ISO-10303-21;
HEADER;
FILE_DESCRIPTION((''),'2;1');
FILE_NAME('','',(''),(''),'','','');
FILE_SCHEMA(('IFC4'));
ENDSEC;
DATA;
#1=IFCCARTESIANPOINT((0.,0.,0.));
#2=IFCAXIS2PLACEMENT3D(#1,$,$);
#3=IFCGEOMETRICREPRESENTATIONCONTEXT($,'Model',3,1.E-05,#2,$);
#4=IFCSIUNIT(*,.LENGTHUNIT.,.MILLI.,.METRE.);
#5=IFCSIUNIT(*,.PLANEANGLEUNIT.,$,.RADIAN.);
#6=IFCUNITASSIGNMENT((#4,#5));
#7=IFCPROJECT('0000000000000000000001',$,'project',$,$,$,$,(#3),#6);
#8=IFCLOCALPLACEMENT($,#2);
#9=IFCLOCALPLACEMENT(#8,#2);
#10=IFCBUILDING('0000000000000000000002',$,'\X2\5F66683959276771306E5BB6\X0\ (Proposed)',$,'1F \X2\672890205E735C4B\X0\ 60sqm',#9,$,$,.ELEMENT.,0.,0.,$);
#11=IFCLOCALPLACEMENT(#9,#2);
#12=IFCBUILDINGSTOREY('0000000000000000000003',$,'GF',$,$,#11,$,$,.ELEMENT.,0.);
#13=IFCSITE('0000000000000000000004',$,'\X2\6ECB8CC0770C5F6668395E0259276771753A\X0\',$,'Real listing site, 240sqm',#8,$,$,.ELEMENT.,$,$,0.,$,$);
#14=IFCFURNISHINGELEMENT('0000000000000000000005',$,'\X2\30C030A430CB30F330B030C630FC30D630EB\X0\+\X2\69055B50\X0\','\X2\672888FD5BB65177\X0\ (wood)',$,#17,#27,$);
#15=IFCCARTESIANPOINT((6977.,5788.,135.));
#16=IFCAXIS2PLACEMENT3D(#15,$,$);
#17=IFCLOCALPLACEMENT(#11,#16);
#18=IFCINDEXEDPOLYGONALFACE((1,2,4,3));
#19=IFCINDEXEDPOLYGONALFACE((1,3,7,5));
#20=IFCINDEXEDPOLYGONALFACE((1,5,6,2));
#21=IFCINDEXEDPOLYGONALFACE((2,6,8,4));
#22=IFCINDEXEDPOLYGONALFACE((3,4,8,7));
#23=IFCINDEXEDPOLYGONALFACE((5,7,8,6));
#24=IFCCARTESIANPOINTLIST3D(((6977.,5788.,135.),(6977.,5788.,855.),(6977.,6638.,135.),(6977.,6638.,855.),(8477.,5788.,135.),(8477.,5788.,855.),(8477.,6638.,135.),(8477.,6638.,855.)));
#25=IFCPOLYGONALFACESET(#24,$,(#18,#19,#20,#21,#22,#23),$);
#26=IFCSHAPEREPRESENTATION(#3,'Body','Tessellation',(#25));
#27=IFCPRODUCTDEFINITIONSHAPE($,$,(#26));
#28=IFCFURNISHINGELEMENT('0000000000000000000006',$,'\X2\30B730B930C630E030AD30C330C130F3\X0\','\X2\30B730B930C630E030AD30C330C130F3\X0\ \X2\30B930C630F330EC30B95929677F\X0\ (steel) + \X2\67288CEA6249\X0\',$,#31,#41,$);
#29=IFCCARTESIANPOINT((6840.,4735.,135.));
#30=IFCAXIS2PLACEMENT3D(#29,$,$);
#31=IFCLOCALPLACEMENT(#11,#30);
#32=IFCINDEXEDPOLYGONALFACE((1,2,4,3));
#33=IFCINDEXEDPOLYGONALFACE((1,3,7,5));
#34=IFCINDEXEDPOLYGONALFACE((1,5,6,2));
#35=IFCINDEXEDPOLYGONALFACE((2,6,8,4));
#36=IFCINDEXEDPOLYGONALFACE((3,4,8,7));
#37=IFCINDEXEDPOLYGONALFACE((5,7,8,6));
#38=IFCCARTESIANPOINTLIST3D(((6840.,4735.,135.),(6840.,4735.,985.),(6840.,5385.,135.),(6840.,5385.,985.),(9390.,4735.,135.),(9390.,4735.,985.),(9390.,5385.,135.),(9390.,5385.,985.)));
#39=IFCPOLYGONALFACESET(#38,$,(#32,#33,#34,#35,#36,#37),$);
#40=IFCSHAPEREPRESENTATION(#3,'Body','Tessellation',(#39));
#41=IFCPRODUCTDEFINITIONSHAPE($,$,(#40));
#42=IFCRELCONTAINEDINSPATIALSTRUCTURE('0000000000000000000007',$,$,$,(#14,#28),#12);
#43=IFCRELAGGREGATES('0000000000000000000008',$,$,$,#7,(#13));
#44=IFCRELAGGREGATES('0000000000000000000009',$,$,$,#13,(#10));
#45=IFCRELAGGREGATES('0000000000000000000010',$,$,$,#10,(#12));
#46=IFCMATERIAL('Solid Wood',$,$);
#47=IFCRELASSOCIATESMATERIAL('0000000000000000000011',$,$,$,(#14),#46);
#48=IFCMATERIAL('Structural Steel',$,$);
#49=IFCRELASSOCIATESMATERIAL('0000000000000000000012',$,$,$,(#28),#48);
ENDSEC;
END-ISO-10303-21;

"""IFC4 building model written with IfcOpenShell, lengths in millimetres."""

from ifc_helpers import new_model, si_unit, frame, frame_2d, origin, place, context, project, spatial, rectangle, extrude, material, element, save


model = new_model("IFC4")

# Units and contexts
model_context = context("Model", 3, precision=1e-05, world=origin())
ifc_project = project(units=[si_unit("LENGTHUNIT", "METRE", prefix="MILLI"), si_unit("PLANEANGLEUNIT", "RADIAN")], contexts=[model_context])

# Site, building, storey
site_placement = place(None, origin())
site = spatial("IfcSite", under=ifc_project, at=site_placement, Name="滋賀県彦根市大東町", ObjectType="Real listing site, 240sqm", CompositionType="ELEMENT", RefElevation=0.0)
building_placement = place(site_placement, origin())
building = spatial("IfcBuilding", under=site, at=building_placement, Name="彦根大東の家 (Proposed)", ObjectType="1F 木造平屋 60sqm", CompositionType="ELEMENT", ElevationOfRefHeight=0.0, ElevationOfTerrain=0.0)
storey_placement = place(building_placement, origin())
storey = spatial("IfcBuildingStorey", under=building, at=storey_placement, Name="GF", CompositionType="ELEMENT", Elevation=0.0)

# Shared definitions
ifc_material_1 = material(Name="Solid Wood")

# Shared definitions
ifc_material_2 = material(Name="Structural Steel")

# Furnishing elements
furnishing_1_placement = place(storey_placement, frame((6977.0, 5788.0, 135.0)))
element("IfcFurnishingElement", 1, at=furnishing_1_placement, inside=storey, material=ifc_material_1, Name="ダイニングテーブル+椅子", Description="木製家具 (wood)", context=model_context, shape_type="SweptSolid", body=[
    extrude(rectangle(XDim=1500.0, YDim=850.0, at=frame_2d((750.0, 425.0))), frame((6977.0, 5788.0, 135.0)), (0.0, 0.0, 1.0), 720.0),
])
furnishing_2_placement = place(storey_placement, frame((6840.0, 4735.0, 135.0)))
element("IfcFurnishingElement", 2, at=furnishing_2_placement, inside=storey, material=ifc_material_2, Name="システムキッチン", Description="システムキッチン ステンレス天板 (steel) + 木質扉", context=model_context, shape_type="SweptSolid", body=[
    extrude(rectangle(XDim=2550.0, YDim=650.0, at=frame_2d((1275.0, 325.0))), frame((6840.0, 4735.0, 135.0)), (0.0, 0.0, 1.0), 850.0),
])

save(model, "model.ifc")
